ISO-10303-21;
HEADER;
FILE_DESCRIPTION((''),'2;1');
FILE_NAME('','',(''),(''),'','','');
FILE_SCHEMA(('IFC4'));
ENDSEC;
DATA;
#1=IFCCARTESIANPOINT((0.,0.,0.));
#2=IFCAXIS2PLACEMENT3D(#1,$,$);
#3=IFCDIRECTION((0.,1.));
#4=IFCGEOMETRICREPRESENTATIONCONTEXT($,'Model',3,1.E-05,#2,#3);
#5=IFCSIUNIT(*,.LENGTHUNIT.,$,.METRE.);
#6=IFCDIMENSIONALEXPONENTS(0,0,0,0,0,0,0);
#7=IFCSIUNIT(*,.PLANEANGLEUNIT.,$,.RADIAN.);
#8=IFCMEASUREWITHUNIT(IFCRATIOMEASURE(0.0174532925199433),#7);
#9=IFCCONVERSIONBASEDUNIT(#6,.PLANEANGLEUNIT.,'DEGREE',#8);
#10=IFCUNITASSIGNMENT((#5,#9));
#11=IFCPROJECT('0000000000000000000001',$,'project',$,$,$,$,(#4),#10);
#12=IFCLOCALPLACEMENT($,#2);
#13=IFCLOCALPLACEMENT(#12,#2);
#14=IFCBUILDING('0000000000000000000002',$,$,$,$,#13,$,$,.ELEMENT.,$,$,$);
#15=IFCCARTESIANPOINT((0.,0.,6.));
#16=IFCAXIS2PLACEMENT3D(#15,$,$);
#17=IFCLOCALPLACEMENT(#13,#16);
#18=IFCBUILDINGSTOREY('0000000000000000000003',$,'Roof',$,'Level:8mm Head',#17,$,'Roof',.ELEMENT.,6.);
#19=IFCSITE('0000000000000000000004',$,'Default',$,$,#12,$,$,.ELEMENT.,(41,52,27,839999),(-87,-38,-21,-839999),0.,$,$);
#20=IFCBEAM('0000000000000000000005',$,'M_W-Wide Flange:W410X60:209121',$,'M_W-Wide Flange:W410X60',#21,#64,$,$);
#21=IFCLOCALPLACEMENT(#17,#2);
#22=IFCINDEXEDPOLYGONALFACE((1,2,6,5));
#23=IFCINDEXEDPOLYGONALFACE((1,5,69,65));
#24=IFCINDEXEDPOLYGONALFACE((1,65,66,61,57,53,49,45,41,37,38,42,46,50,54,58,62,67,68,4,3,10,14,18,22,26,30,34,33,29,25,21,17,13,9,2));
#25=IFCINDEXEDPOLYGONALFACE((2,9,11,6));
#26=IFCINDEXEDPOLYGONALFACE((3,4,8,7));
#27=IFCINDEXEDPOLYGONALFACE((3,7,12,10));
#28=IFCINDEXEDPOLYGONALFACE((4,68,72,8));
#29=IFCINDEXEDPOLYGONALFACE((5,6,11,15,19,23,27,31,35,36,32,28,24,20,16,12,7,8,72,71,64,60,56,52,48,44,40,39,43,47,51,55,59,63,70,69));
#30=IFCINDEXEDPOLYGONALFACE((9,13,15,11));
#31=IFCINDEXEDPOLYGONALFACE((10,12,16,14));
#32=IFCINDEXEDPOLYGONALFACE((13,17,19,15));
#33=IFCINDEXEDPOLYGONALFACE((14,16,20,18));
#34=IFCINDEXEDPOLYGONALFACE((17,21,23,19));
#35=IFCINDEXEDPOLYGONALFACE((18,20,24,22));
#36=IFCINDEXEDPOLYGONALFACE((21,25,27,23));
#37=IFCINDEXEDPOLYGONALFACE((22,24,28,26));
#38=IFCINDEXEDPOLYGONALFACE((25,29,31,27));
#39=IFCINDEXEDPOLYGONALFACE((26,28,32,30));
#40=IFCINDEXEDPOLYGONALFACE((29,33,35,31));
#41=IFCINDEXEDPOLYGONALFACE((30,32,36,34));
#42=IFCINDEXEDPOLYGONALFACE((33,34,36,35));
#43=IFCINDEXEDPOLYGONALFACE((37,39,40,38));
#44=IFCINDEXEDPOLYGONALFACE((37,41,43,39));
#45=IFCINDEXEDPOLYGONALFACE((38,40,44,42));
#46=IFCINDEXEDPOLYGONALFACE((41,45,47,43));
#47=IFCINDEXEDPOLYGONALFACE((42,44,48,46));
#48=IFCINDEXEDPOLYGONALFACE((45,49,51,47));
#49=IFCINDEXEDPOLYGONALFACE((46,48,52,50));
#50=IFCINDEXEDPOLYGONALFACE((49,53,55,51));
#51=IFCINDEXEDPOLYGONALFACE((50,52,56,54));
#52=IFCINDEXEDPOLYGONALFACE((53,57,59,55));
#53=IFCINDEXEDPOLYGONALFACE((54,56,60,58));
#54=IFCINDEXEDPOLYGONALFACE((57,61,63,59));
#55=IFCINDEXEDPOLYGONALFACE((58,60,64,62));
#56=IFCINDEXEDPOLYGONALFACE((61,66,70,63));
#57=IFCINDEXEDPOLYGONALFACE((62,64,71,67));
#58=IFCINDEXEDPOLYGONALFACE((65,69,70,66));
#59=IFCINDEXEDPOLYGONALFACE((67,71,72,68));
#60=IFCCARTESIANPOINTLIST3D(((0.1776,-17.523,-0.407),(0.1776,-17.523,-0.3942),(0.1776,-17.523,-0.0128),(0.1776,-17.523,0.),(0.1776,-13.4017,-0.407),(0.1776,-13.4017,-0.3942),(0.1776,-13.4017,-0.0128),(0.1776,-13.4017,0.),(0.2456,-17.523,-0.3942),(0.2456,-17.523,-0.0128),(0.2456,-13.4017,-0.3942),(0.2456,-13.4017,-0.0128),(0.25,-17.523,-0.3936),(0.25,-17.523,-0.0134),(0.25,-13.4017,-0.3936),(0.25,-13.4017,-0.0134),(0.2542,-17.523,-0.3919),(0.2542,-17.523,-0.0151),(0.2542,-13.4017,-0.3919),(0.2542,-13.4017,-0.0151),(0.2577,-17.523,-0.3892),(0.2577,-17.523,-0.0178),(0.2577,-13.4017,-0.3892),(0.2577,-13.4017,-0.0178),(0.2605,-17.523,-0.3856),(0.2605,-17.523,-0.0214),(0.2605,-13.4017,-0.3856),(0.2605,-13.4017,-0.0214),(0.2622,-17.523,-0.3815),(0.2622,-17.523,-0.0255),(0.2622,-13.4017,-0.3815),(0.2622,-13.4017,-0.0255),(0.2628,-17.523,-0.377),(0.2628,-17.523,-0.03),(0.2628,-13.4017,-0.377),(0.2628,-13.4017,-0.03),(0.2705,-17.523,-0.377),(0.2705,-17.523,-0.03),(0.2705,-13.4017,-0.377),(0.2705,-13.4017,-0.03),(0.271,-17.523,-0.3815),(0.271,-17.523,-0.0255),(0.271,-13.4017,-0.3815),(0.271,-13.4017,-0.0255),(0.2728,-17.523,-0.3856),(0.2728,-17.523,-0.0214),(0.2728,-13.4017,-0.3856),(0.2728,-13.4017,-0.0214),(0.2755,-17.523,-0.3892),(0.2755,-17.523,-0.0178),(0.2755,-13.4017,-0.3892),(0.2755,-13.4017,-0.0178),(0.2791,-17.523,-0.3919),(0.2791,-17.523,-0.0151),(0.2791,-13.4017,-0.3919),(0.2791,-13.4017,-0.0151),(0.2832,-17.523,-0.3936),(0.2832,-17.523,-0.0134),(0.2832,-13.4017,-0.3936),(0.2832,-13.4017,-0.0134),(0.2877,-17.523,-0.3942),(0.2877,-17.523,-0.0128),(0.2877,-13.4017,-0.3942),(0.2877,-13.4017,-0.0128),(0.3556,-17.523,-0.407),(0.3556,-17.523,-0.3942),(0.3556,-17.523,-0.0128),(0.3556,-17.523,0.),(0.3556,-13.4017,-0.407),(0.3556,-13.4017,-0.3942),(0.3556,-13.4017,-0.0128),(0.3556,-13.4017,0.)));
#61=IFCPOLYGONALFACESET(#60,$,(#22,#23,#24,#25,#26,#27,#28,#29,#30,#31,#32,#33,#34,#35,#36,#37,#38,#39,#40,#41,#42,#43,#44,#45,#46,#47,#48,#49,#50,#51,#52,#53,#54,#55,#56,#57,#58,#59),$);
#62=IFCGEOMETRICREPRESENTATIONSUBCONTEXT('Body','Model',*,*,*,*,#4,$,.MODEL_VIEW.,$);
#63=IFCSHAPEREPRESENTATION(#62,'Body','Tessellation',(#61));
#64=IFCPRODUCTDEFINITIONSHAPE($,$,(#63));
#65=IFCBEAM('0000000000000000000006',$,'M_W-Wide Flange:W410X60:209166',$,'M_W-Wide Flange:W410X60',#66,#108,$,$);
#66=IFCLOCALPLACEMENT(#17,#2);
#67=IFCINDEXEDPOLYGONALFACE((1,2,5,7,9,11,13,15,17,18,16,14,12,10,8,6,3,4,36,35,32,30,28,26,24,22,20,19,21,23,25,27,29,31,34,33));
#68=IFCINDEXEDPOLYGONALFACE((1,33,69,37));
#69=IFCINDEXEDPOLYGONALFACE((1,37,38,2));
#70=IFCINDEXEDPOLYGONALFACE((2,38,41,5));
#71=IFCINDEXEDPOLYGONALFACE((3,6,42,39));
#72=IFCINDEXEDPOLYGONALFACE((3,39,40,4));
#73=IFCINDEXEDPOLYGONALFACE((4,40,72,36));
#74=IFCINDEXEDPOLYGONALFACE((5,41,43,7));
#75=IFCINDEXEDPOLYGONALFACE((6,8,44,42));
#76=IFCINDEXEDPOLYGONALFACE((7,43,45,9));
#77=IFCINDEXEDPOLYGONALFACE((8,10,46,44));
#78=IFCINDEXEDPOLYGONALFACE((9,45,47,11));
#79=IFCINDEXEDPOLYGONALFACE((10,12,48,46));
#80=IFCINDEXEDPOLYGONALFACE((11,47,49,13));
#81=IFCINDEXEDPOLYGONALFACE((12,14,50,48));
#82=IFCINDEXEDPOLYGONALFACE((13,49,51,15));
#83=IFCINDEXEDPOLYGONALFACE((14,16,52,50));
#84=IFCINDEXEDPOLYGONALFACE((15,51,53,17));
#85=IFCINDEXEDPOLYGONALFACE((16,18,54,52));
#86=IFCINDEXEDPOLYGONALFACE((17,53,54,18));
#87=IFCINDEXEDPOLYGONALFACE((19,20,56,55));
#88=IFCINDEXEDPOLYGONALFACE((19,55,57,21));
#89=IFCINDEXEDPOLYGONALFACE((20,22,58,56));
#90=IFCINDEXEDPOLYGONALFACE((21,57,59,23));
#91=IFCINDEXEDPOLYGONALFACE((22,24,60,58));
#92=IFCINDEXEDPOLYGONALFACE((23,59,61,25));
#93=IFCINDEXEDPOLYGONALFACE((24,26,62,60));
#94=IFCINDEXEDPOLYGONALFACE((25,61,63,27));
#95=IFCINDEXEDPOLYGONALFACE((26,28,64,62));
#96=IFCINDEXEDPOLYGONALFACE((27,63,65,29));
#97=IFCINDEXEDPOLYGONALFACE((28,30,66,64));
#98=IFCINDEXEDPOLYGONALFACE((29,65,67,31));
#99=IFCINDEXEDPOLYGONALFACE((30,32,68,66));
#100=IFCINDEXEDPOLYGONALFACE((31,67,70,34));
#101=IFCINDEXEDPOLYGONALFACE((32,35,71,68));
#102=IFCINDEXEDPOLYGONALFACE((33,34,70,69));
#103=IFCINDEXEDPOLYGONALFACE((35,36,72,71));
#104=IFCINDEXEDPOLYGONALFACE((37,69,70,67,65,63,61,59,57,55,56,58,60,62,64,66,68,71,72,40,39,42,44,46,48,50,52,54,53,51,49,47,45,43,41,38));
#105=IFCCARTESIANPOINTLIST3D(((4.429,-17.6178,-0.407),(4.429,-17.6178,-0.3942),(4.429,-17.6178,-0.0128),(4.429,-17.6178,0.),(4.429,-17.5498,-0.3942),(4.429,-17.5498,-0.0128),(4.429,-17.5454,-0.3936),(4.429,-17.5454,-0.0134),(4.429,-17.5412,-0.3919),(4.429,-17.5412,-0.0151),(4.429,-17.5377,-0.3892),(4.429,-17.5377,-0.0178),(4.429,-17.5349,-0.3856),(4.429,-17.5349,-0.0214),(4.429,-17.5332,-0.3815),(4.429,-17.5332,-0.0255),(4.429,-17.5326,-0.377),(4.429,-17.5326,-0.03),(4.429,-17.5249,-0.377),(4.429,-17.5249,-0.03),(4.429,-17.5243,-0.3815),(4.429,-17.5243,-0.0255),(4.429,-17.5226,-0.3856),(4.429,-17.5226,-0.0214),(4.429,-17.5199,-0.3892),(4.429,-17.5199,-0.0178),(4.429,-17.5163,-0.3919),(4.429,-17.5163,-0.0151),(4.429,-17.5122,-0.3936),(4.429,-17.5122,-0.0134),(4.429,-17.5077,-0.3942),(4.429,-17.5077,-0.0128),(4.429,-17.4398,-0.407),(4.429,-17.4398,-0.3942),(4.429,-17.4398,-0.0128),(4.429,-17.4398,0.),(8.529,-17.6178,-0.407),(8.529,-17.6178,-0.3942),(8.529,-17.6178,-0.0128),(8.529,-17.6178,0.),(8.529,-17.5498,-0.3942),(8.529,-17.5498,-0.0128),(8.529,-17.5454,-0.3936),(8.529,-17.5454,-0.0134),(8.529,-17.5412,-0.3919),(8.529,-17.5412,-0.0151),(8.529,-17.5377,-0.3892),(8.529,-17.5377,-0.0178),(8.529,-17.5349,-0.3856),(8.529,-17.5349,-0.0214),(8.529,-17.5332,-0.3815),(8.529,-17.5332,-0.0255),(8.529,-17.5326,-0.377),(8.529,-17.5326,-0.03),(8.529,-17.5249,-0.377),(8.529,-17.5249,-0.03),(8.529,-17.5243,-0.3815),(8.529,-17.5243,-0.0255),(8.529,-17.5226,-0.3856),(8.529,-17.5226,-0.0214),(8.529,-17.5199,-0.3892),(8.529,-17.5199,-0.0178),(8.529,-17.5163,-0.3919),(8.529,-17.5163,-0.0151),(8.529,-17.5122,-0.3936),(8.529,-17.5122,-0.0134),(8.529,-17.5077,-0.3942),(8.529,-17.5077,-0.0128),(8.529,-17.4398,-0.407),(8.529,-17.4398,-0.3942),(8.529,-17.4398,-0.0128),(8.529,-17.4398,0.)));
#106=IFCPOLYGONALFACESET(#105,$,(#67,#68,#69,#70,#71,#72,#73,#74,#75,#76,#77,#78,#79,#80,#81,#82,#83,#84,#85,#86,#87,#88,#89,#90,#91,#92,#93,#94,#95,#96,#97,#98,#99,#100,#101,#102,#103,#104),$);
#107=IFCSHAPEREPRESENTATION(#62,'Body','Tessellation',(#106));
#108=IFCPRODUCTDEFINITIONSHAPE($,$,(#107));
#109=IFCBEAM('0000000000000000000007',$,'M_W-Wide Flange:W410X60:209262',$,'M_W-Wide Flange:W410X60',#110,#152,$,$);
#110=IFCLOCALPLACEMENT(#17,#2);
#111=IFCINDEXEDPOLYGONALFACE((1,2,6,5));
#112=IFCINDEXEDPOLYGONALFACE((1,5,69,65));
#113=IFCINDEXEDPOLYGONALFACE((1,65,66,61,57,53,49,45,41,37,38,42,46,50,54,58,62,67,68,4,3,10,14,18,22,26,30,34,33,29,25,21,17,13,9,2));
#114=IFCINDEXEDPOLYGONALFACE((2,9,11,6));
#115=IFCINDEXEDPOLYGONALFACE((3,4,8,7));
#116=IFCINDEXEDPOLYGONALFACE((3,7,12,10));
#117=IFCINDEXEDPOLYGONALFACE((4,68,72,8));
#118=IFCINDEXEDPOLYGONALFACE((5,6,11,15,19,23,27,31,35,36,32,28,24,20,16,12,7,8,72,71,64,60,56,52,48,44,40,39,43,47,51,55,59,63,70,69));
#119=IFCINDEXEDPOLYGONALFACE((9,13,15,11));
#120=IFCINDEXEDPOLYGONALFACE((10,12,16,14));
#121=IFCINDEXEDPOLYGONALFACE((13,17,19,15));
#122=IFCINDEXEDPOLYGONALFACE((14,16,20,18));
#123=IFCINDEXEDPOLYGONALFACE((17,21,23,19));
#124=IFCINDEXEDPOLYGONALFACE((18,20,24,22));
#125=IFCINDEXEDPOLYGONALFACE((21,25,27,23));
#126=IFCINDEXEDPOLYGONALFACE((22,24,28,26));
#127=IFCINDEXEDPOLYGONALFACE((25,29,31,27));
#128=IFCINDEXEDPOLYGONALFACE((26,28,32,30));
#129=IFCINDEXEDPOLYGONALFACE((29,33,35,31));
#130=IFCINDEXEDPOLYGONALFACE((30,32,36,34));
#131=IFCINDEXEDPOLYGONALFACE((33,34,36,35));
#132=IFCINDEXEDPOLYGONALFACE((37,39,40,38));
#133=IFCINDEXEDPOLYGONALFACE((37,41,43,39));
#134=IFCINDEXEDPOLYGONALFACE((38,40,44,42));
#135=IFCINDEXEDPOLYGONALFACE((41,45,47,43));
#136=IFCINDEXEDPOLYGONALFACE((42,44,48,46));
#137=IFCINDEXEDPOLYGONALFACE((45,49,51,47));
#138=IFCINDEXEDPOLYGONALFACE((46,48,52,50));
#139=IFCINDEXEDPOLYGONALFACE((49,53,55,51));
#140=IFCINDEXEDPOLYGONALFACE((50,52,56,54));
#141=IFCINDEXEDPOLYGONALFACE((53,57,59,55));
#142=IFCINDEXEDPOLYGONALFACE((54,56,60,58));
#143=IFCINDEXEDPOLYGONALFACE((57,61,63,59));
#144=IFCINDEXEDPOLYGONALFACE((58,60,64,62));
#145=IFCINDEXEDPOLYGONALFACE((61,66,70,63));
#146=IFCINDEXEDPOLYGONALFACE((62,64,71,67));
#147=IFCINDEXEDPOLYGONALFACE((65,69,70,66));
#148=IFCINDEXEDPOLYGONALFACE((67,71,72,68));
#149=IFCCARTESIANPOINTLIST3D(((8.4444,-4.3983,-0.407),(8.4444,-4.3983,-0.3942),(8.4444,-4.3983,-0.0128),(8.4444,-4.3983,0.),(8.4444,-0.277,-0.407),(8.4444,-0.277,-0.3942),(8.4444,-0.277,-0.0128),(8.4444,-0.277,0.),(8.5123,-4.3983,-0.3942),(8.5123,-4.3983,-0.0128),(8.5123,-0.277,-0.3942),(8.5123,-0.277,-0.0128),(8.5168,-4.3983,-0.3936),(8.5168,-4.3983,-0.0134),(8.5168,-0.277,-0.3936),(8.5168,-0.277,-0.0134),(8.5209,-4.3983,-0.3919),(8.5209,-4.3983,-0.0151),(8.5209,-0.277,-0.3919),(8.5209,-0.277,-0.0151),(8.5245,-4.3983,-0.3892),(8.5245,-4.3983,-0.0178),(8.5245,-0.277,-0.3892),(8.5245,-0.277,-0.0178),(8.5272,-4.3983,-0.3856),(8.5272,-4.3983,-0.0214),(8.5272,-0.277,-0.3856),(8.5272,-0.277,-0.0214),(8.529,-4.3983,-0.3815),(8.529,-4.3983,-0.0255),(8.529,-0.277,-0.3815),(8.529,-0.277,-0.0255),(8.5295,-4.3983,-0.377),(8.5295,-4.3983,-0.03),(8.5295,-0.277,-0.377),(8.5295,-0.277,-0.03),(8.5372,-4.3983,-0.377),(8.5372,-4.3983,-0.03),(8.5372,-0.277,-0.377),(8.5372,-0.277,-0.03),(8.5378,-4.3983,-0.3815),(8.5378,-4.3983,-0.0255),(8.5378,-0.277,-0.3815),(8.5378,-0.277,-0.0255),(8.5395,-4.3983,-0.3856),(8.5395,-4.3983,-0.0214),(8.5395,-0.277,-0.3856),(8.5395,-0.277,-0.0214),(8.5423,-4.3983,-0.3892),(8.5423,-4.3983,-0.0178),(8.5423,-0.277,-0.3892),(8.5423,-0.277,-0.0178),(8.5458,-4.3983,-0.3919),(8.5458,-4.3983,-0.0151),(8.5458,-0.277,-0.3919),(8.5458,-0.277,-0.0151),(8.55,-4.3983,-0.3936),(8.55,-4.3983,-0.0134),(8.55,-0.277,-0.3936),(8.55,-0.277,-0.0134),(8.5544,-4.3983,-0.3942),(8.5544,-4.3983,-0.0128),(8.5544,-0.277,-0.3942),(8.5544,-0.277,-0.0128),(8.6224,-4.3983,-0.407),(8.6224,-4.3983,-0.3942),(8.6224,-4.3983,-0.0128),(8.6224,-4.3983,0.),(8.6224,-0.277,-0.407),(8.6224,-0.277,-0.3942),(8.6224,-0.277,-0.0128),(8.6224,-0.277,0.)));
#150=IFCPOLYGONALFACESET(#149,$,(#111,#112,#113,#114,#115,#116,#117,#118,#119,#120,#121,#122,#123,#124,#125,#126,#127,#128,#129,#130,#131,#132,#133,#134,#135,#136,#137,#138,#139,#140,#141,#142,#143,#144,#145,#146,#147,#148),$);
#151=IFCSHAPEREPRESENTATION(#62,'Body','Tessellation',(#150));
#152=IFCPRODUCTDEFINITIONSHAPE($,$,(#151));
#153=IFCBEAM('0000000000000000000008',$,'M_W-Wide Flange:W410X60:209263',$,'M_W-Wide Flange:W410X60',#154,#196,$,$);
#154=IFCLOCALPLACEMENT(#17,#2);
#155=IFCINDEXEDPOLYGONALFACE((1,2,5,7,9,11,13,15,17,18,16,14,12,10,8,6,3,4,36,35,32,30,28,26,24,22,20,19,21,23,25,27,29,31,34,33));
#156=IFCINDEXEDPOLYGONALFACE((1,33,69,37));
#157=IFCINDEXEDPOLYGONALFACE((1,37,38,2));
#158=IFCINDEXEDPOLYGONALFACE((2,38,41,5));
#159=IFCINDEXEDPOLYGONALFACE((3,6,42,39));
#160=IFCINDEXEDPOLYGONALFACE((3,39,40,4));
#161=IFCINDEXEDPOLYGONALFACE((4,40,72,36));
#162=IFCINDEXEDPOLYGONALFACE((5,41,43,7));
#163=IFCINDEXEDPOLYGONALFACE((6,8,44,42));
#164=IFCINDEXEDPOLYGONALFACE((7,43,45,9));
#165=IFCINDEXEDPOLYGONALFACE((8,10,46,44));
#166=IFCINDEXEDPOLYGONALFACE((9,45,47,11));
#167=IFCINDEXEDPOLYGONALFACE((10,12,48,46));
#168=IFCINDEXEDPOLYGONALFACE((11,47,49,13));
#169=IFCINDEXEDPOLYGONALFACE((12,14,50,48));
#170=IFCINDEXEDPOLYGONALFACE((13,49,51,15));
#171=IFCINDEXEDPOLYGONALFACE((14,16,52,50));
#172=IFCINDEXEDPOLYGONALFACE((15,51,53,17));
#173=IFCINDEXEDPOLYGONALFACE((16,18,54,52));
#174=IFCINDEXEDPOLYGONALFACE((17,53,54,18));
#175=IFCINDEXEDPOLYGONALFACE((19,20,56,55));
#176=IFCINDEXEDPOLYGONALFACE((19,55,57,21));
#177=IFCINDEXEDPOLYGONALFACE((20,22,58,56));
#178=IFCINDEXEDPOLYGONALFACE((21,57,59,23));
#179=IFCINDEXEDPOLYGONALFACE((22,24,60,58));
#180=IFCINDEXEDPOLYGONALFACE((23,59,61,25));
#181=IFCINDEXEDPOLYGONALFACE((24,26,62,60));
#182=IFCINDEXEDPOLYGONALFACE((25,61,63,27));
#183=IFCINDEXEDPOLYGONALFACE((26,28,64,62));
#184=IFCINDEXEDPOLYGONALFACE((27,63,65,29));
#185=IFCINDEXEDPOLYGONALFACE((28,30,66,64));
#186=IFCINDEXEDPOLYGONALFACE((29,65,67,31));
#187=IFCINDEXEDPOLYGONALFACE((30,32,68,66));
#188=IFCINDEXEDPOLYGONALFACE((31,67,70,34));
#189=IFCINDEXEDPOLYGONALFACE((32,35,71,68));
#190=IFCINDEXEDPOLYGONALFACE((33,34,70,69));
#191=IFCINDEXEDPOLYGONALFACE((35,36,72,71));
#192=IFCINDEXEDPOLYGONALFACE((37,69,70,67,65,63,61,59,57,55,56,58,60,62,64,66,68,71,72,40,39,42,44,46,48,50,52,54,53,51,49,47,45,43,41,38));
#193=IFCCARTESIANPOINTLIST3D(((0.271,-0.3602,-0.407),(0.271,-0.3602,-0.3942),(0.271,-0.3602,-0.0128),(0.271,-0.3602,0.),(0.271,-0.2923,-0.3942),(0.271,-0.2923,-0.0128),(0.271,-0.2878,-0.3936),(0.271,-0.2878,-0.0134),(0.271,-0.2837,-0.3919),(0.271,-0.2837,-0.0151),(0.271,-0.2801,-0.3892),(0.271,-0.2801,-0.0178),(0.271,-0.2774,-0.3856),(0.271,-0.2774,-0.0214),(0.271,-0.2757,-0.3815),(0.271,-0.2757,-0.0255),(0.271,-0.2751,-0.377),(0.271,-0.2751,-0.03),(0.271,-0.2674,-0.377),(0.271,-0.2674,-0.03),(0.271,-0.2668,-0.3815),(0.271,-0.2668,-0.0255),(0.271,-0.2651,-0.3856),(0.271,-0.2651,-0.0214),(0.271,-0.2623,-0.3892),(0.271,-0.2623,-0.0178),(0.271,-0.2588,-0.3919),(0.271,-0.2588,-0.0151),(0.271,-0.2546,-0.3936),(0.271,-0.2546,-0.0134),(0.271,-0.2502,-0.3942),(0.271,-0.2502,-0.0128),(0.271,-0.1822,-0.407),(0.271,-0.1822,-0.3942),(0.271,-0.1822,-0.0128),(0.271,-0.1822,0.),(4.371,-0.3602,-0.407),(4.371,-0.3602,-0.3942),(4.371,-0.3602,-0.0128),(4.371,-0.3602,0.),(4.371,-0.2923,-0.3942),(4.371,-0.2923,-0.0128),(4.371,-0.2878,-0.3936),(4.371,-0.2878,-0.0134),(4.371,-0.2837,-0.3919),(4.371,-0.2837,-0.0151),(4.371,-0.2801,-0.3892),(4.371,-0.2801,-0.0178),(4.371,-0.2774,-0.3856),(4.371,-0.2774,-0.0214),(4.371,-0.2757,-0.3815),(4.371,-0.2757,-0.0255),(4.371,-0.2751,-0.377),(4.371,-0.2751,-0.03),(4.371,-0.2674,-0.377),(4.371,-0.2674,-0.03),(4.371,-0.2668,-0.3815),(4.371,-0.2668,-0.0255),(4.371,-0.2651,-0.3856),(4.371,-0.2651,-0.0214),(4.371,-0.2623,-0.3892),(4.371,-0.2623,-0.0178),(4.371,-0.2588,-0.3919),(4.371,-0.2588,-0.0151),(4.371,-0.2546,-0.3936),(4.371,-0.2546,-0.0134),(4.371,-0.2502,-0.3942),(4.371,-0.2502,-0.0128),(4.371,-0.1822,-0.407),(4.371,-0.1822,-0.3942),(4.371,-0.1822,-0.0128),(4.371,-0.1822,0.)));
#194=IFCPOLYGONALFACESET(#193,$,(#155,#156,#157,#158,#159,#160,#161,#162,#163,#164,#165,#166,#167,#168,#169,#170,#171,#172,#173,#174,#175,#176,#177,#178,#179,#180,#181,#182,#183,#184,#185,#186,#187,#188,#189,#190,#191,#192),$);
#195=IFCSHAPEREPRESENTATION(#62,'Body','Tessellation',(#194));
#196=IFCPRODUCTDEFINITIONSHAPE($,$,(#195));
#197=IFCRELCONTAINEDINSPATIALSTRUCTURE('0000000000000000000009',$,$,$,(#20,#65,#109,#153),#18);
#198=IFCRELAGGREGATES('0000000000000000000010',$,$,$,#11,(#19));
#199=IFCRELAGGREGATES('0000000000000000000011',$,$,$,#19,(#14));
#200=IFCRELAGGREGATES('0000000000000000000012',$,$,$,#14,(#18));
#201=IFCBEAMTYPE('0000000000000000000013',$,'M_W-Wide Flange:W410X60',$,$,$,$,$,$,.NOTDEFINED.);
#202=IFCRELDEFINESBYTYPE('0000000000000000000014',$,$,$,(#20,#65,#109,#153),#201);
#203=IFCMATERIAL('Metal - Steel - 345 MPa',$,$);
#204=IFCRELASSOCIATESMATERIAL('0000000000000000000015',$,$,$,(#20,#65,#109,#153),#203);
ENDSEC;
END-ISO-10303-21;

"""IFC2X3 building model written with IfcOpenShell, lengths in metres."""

from ifc_helpers import new_model, entity, si_unit, converted_unit, direction, frame, frame_2d, origin, place, context, subcontext, project, spatial, i_section, extrude, material, type_object, element, save


model = new_model("IFC2X3")

# Units and contexts
model_context = context("Model", 3, precision=1e-05, world=origin(), true_north=direction((0.0, 1.0)))
body_context = subcontext(model_context, "Body", "Model", "MODEL_VIEW")
ifc_project = project(units=[si_unit("LENGTHUNIT", "METRE"), converted_unit("PLANEANGLEUNIT", "DEGREE", entity("IfcRatioMeasure", 0.0174532925199433), si_unit("PLANEANGLEUNIT", "RADIAN"), dimensions=[0, 0, 0, 0, 0, 0, 0])], contexts=[model_context])

# Site, building, storey
site_placement = place(None, origin())
site = spatial("IfcSite", under=ifc_project, at=site_placement, Name="Default", CompositionType="ELEMENT", RefLatitude=(41, 52, 27, 839999), RefLongitude=(-87, -38, -21, -839999), RefElevation=0.0)
building_placement = place(site_placement, origin())
building = spatial("IfcBuilding", under=site, at=building_placement, CompositionType="ELEMENT")
storey_placement = place(building_placement, frame((0.0, 0.0, 6.0)))
storey = spatial("IfcBuildingStorey", under=building, at=storey_placement, Name="Roof", ObjectType="Level:8mm Head", LongName="Roof", CompositionType="ELEMENT", Elevation=6.0)

# Beams
ifc_material_1 = material(Name="Metal - Steel - 345 MPa")
beam_type = type_object("IfcBeamType", Name="M_W-Wide Flange:W410X60", PredefinedType="NOTDEFINED")
beam_1_placement = place(storey_placement, frame((0.2666, -13.4017, 0.0), z_axis=(0.0, 0.0, 1.0), x_axis=(0.0, -1.0, 0.0)))
element("IfcBeam", 1, at=beam_1_placement, inside=storey, type_object=beam_type, material=ifc_material_1, Name="M_W-Wide Flange:W410X60:209121", ObjectType="M_W-Wide Flange:W410X60", context=body_context, shape_type="SweptSolid", body=[
    extrude(i_section(OverallWidth=0.178, OverallDepth=0.407, WebThickness=0.0077, FlangeThickness=0.0128, FilletRadius=0.0172, at=frame_2d((0.0, 0.0), x_axis=(0.0, 1.0))), frame((0.0, 0.0, -0.2035), z_axis=(1.0, 0.0, 0.0), x_axis=(0.0, 0.0, -1.0)), (0.0, 0.0, 1.0), 4.1213),
])
beam_2_placement = place(storey_placement, frame((4.429, -17.5288, 0.0)))
element("IfcBeam", 2, at=beam_2_placement, inside=storey, type_object=beam_type, material=ifc_material_1, Name="M_W-Wide Flange:W410X60:209166", ObjectType="M_W-Wide Flange:W410X60", context=body_context, shape_type="SweptSolid", body=[
    extrude(i_section(OverallWidth=0.178, OverallDepth=0.407, WebThickness=0.0077, FlangeThickness=0.0128, FilletRadius=0.0172, at=frame_2d((0.0, 0.0), x_axis=(0.0, 1.0))), frame((0.0, 0.0, -0.2035), z_axis=(1.0, 0.0, 0.0), x_axis=(0.0, 0.0, -1.0)), (0.0, 0.0, 1.0), 4.1),
])
beam_3_placement = place(storey_placement, frame((8.5334, -4.3983, 0.0), z_axis=(0.0, 0.0, 1.0), x_axis=(0.0, 1.0, 0.0)))
element("IfcBeam", 3, at=beam_3_placement, inside=storey, type_object=beam_type, material=ifc_material_1, Name="M_W-Wide Flange:W410X60:209262", ObjectType="M_W-Wide Flange:W410X60", context=body_context, shape_type="SweptSolid", body=[
    extrude(i_section(OverallWidth=0.178, OverallDepth=0.407, WebThickness=0.0077, FlangeThickness=0.0128, FilletRadius=0.0172, at=frame_2d((0.0, 0.0), x_axis=(0.0, 1.0))), frame((0.0, 0.0, -0.2035), z_axis=(1.0, 0.0, 0.0), x_axis=(0.0, 0.0, -1.0)), (0.0, 0.0, 1.0), 4.1213),
])
beam_4_placement = place(storey_placement, frame((4.371, -0.2712, 0.0), z_axis=(0.0, 0.0, 1.0), x_axis=(-1.0, 0.0, 0.0)))
element("IfcBeam", 4, at=beam_4_placement, inside=storey, type_object=beam_type, material=ifc_material_1, Name="M_W-Wide Flange:W410X60:209263", ObjectType="M_W-Wide Flange:W410X60", context=body_context, shape_type="SweptSolid", body=[
    extrude(i_section(OverallWidth=0.178, OverallDepth=0.407, WebThickness=0.0077, FlangeThickness=0.0128, FilletRadius=0.0172, at=frame_2d((0.0, 0.0), x_axis=(0.0, 1.0))), frame((0.0, 0.0, -0.2035), z_axis=(1.0, 0.0, 0.0), x_axis=(0.0, 0.0, -1.0)), (0.0, 0.0, 1.0), 4.1),
])

save(model, "model.ifc")
